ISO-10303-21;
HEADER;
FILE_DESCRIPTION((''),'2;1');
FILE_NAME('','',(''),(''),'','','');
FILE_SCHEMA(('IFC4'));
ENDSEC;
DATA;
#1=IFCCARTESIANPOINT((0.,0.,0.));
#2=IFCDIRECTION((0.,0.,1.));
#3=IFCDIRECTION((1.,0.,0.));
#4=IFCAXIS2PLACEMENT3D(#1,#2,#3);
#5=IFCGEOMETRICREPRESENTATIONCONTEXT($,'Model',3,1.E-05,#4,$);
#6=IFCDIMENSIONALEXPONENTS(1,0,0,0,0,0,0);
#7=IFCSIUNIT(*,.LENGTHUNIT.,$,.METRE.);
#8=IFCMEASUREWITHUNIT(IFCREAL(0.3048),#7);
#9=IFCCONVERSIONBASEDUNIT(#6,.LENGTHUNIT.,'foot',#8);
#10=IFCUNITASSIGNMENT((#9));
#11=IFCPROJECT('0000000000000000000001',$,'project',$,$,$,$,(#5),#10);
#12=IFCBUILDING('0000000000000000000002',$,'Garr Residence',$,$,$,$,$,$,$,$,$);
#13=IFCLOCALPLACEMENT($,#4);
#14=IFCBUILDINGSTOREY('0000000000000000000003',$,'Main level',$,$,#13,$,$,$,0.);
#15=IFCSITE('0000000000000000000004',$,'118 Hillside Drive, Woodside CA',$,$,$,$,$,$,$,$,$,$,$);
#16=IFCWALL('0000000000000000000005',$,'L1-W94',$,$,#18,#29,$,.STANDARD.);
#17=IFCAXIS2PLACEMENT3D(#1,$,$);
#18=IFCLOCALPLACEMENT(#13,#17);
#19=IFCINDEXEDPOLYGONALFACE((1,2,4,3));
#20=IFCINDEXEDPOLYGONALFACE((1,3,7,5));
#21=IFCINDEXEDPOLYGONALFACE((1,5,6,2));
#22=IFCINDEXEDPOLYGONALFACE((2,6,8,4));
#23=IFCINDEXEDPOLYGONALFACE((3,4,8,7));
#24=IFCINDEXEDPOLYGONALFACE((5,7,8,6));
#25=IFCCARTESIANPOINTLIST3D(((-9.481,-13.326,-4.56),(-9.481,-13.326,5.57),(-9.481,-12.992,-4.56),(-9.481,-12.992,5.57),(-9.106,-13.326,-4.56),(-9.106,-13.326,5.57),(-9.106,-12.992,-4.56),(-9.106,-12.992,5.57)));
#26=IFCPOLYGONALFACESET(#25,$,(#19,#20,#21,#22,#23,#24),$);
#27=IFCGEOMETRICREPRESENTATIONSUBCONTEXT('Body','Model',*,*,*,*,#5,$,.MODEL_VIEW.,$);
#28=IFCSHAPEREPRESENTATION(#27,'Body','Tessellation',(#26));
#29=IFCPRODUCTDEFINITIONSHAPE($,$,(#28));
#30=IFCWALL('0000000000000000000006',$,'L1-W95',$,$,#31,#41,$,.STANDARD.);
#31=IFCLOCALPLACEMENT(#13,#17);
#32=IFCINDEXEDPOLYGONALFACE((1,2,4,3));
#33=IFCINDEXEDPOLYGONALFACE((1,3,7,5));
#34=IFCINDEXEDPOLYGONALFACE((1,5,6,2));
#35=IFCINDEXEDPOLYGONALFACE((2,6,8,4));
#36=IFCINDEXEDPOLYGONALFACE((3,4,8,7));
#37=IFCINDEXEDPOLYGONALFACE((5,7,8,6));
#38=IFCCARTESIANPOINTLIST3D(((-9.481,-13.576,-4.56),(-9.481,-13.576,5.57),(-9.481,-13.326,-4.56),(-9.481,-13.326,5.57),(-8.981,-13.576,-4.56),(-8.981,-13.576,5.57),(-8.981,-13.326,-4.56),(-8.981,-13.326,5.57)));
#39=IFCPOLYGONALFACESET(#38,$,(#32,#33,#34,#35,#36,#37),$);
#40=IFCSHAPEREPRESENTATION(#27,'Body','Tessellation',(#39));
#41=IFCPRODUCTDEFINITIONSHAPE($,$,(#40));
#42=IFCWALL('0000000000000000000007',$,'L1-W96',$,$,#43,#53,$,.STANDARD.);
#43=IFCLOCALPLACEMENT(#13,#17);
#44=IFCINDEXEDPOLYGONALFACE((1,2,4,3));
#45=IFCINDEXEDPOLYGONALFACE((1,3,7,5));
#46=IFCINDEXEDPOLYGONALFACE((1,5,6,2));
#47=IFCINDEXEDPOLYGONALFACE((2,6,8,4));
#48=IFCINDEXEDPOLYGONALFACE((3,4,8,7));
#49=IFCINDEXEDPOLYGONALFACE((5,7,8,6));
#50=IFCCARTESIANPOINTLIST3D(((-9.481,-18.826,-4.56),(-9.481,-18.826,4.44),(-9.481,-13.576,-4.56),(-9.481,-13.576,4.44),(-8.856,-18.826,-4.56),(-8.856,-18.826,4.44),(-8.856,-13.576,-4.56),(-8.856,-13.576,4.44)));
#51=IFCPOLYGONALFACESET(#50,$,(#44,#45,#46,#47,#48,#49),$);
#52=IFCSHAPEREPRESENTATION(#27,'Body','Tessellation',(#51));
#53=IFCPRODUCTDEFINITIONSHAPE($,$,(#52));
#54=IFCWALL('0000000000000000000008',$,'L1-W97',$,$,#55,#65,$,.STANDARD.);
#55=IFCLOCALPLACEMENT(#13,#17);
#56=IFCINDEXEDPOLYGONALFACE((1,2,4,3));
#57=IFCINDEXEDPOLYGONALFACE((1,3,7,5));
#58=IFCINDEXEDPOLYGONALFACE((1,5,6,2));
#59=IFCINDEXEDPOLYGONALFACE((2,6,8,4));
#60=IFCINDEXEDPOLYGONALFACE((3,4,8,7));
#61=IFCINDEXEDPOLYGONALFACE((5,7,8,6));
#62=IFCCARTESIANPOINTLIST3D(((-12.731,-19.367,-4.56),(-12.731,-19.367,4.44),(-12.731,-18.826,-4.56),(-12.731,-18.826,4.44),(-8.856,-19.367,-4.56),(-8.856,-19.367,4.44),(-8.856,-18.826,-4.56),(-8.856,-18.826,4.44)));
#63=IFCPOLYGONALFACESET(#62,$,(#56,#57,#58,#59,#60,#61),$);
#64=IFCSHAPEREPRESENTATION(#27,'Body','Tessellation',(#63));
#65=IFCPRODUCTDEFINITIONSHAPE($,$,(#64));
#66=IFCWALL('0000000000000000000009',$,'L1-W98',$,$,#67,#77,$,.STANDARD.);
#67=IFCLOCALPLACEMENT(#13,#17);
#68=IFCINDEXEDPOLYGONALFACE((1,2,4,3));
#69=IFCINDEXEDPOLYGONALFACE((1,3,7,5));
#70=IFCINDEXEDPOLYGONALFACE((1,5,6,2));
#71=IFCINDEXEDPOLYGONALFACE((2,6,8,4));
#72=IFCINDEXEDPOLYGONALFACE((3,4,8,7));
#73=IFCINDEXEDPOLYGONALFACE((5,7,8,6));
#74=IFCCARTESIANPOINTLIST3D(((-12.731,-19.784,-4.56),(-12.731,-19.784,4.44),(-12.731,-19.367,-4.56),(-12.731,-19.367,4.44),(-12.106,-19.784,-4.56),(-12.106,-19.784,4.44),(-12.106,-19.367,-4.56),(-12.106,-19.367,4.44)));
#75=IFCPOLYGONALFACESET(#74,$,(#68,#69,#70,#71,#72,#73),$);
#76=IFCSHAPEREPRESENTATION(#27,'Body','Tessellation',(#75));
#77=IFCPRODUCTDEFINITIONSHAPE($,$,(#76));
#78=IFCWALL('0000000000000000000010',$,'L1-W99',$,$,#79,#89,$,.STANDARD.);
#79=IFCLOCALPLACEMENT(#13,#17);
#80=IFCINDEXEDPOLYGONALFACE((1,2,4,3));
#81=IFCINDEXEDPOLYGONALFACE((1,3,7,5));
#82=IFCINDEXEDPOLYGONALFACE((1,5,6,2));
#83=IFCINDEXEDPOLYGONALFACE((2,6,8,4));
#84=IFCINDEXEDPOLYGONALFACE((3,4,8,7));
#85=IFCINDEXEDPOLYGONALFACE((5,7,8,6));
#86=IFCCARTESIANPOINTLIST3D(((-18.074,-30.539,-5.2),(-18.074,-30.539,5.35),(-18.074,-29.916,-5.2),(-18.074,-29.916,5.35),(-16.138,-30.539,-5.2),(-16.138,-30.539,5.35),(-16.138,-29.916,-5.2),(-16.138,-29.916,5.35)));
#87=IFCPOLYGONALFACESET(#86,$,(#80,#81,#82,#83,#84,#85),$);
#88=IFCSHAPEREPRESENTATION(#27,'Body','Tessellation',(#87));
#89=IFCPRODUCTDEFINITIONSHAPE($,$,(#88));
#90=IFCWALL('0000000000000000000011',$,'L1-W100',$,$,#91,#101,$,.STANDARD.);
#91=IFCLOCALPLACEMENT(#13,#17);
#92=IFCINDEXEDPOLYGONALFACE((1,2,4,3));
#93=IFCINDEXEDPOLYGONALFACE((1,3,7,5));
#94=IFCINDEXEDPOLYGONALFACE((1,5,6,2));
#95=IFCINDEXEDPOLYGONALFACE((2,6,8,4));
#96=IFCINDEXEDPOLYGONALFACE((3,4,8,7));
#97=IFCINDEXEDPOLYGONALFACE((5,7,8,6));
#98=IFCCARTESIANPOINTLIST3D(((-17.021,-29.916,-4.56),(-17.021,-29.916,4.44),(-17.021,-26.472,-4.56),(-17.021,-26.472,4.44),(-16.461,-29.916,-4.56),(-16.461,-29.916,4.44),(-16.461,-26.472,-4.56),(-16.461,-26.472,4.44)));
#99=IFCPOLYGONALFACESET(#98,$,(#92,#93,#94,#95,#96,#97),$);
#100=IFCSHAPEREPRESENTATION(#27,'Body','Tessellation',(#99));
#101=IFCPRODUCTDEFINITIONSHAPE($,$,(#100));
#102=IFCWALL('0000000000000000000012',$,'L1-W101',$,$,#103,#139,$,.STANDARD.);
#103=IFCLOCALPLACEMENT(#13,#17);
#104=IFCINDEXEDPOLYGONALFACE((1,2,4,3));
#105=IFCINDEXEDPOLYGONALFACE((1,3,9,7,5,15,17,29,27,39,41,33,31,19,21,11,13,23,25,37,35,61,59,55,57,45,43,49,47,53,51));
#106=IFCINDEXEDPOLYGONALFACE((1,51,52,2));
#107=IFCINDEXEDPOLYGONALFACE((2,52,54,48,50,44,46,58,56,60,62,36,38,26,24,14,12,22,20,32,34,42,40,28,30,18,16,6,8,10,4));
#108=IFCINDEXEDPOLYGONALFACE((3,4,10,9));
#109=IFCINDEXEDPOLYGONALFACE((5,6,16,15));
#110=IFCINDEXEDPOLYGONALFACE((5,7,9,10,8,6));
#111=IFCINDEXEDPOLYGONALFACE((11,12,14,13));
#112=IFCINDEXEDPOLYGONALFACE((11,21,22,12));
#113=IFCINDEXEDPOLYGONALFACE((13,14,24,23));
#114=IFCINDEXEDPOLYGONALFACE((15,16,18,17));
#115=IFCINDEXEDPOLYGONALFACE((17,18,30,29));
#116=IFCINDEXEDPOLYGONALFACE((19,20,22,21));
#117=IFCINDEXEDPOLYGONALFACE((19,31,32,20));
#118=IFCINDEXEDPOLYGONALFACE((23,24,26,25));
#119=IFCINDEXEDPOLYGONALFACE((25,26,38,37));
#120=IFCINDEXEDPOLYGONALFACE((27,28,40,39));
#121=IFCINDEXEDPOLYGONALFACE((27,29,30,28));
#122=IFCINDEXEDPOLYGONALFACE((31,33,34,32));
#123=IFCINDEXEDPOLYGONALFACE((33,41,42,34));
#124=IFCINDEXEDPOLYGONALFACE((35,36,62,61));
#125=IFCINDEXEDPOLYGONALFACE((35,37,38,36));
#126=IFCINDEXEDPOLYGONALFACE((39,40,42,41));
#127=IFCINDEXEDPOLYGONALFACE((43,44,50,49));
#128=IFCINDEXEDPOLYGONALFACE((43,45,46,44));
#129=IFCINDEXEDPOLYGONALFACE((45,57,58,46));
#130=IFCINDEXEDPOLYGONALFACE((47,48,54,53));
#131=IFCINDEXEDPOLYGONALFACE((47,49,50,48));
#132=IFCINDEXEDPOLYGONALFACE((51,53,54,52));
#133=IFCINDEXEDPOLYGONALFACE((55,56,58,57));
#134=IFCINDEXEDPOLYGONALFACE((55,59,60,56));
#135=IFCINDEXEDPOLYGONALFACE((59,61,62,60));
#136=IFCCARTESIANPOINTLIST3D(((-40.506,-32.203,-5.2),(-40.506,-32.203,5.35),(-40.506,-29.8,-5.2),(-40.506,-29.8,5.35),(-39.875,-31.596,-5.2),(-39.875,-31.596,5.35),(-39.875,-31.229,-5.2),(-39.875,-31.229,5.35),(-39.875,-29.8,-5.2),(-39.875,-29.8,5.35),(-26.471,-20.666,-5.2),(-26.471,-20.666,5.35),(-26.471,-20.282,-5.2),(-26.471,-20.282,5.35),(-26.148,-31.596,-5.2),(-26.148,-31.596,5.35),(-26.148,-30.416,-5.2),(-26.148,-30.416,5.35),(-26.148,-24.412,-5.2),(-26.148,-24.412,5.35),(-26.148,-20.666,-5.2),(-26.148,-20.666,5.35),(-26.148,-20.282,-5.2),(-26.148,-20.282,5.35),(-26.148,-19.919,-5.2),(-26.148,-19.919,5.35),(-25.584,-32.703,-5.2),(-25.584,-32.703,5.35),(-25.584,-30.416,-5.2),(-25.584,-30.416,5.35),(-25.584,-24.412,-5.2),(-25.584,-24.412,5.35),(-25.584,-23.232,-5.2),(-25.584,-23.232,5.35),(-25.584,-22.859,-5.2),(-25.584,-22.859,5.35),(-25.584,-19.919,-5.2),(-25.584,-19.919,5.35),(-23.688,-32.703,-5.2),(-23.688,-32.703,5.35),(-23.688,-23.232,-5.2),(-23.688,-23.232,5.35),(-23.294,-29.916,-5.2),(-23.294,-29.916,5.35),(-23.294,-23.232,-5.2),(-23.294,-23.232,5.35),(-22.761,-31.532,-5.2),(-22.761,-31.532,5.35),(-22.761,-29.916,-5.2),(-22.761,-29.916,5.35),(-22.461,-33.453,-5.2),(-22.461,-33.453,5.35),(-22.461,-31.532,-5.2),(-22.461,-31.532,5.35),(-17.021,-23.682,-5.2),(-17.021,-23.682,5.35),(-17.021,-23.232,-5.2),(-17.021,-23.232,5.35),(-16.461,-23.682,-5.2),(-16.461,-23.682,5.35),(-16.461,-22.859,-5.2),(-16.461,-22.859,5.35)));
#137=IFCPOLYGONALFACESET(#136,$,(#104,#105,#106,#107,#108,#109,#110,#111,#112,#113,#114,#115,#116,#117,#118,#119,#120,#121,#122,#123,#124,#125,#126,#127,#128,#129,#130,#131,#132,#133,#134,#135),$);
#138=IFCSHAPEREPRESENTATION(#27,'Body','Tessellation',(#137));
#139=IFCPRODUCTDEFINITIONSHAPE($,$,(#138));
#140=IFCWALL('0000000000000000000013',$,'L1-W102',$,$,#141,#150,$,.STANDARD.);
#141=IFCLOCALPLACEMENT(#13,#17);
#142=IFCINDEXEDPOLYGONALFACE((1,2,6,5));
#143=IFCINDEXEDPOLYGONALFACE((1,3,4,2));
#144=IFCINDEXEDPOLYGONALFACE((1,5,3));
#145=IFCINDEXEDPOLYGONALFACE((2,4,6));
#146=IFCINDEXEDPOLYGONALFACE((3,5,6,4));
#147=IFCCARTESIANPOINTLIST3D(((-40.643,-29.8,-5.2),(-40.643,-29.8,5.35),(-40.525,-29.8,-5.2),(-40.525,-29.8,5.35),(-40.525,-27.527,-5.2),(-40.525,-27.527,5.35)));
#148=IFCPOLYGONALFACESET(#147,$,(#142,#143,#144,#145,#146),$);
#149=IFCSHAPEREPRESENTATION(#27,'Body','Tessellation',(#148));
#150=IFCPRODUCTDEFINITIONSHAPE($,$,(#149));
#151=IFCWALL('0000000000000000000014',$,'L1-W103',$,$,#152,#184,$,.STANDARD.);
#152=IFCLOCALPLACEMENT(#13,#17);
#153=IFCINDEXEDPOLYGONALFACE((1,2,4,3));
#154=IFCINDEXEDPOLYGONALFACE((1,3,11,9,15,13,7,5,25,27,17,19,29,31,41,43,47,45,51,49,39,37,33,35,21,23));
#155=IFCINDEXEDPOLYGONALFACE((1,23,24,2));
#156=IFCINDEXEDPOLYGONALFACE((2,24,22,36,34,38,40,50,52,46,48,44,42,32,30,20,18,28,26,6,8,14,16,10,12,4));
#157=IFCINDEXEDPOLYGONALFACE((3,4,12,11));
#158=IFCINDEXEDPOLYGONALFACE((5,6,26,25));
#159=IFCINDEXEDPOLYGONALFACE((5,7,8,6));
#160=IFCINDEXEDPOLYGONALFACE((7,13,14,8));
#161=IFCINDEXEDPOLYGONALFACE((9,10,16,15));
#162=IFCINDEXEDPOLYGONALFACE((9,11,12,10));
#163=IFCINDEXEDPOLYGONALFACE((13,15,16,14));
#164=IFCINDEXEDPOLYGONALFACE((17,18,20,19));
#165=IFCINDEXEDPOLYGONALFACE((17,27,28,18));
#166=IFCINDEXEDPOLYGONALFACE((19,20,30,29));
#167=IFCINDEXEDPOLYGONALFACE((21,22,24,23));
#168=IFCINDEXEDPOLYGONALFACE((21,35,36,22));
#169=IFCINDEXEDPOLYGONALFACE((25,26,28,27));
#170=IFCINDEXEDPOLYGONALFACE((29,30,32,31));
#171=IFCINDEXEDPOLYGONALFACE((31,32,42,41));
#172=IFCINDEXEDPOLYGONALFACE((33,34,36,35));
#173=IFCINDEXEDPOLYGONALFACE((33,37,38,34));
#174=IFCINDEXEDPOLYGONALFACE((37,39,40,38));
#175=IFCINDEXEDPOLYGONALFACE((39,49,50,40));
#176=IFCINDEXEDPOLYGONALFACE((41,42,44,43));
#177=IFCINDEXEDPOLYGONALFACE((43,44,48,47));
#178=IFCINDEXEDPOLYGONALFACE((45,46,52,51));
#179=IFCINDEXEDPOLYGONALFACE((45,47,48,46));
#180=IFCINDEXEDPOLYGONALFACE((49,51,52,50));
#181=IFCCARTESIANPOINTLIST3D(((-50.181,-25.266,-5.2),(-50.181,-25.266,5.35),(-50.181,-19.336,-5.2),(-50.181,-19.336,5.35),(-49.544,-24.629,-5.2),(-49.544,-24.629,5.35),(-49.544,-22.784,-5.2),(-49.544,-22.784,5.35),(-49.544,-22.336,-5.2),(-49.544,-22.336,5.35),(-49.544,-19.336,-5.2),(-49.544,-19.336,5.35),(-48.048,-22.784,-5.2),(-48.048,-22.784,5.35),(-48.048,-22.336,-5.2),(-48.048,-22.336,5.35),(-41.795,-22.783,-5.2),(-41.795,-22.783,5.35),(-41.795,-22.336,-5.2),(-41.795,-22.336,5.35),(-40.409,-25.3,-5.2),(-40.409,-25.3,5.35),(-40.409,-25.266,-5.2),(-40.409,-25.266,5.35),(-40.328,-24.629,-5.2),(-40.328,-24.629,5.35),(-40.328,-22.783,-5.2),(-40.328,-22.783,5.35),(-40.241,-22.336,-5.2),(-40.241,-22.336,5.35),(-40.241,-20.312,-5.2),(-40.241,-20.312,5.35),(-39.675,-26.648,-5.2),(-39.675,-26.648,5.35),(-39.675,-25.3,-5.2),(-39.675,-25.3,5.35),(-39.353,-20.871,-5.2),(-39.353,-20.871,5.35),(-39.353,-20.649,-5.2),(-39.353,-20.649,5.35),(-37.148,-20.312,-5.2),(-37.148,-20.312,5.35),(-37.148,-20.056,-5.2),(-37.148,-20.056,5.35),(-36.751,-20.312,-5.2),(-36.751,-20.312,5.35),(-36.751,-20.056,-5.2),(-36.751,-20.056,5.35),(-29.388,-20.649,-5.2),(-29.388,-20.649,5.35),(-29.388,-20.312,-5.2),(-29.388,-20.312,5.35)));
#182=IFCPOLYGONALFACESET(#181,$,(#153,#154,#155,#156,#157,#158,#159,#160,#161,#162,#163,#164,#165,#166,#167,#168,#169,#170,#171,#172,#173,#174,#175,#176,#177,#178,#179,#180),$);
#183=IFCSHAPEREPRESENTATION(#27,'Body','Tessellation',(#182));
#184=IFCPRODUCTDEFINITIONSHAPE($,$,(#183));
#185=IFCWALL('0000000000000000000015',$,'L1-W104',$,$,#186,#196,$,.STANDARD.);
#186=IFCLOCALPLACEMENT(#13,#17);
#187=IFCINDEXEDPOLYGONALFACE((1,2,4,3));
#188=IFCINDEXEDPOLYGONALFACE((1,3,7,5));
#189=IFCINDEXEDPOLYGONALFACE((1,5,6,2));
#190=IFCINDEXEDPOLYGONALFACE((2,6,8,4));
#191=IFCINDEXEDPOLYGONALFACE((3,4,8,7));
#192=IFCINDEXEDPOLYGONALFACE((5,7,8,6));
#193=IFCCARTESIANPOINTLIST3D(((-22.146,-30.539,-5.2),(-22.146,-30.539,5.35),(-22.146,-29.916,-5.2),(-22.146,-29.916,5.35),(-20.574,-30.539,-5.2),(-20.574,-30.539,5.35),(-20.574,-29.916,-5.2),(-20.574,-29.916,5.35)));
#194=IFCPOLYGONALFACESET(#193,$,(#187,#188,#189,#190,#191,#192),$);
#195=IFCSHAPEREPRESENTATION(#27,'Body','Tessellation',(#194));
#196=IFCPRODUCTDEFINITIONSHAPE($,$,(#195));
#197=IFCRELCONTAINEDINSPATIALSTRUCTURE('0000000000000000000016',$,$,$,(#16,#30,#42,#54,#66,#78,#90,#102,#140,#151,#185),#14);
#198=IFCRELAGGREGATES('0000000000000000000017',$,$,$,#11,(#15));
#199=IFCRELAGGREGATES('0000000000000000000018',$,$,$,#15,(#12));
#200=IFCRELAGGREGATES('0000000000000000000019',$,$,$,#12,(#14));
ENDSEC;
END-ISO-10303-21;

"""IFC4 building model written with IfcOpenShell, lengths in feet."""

from ifc_helpers import new_model, entity, si_unit, converted_unit, frame, origin, origin_with_axes, place, context, subcontext, project, spatial, polyline, outline, extrude, element, save


model = new_model("IFC4")

# Units and contexts
model_context = context("Model", 3, precision=1e-05, world=origin_with_axes())
body_context = subcontext(model_context, "Body", "Model", "MODEL_VIEW")
ifc_project = project(units=[converted_unit("LENGTHUNIT", "foot", entity("IfcReal", 0.3048), si_unit("LENGTHUNIT", "METRE"), dimensions=[1, 0, 0, 0, 0, 0, 0])], contexts=[model_context])

# Site, building, storey
site = spatial("IfcSite", under=ifc_project, Name="118 Hillside Drive, Woodside CA")
building = spatial("IfcBuilding", under=site, Name="Garr Residence")
storey_placement = place(None, origin_with_axes())
storey = spatial("IfcBuildingStorey", under=building, at=storey_placement, Name="Main level", Elevation=0.0)

# Walls
wall_1_placement = place(storey_placement, frame((0.0, 0.0, -4.56), z_axis=(0.0, 0.0, 1.0), x_axis=(1.0, 0.0, 0.0)))
element("IfcWall", 1, at=wall_1_placement, inside=storey, Name="L1-W94", PredefinedType="STANDARD", context=body_context, shape_type="SweptSolid", body=[
    extrude(outline(polyline([(-9.106, -13.326), (-9.106, -12.992), (-9.481, -12.992), (-9.481, -13.326), (-9.106, -13.326)])), origin(), (0.0, 0.0, 1.0), 10.13),
])
wall_2_placement = place(storey_placement, frame((0.0, 0.0, -4.56), z_axis=(0.0, 0.0, 1.0), x_axis=(1.0, 0.0, 0.0)))
element("IfcWall", 2, at=wall_2_placement, inside=storey, Name="L1-W95", PredefinedType="STANDARD", context=body_context, shape_type="SweptSolid", body=[
    extrude(outline(polyline([(-8.981, -13.576), (-8.981, -13.326), (-9.481, -13.326), (-9.481, -13.576), (-8.981, -13.576)])), origin(), (0.0, 0.0, 1.0), 10.13),
])
wall_3_placement = place(storey_placement, frame((0.0, 0.0, -4.56), z_axis=(0.0, 0.0, 1.0), x_axis=(1.0, 0.0, 0.0)))
element("IfcWall", 3, at=wall_3_placement, inside=storey, Name="L1-W96", PredefinedType="STANDARD", context=body_context, shape_type="SweptSolid", body=[
    extrude(outline(polyline([(-8.856, -18.826), (-8.856, -13.576), (-9.481, -13.576), (-9.481, -18.826), (-8.856, -18.826)])), origin(), (0.0, 0.0, 1.0), 9.0),
])
wall_4_placement = place(storey_placement, frame((0.0, 0.0, -4.56), z_axis=(0.0, 0.0, 1.0), x_axis=(1.0, 0.0, 0.0)))
element("IfcWall", 4, at=wall_4_placement, inside=storey, Name="L1-W97", PredefinedType="STANDARD", context=body_context, shape_type="SweptSolid", body=[
    extrude(outline(polyline([(-8.856, -19.367), (-8.856, -18.826), (-12.731, -18.826), (-12.731, -19.367), (-8.856, -19.367)])), origin(), (0.0, 0.0, 1.0), 9.0),
])
wall_5_placement = place(storey_placement, frame((0.0, 0.0, -4.56), z_axis=(0.0, 0.0, 1.0), x_axis=(1.0, 0.0, 0.0)))
element("IfcWall", 5, at=wall_5_placement, inside=storey, Name="L1-W98", PredefinedType="STANDARD", context=body_context, shape_type="SweptSolid", body=[
    extrude(outline(polyline([(-12.106, -19.784), (-12.106, -19.367), (-12.731, -19.367), (-12.731, -19.784), (-12.106, -19.784)])), origin(), (0.0, 0.0, 1.0), 9.0),
])
wall_6_placement = place(storey_placement, frame((0.0, 0.0, -5.2), z_axis=(0.0, 0.0, 1.0), x_axis=(1.0, 0.0, 0.0)))
element("IfcWall", 6, at=wall_6_placement, inside=storey, Name="L1-W99", PredefinedType="STANDARD", context=body_context, shape_type="SweptSolid", body=[
    extrude(outline(polyline([(-16.138, -30.539), (-16.138, -29.916), (-18.074, -29.916), (-18.074, -30.539), (-16.138, -30.539)])), origin(), (0.0, 0.0, 1.0), 10.55),
])
wall_7_placement = place(storey_placement, frame((0.0, 0.0, -4.56), z_axis=(0.0, 0.0, 1.0), x_axis=(1.0, 0.0, 0.0)))
element("IfcWall", 7, at=wall_7_placement, inside=storey, Name="L1-W100", PredefinedType="STANDARD", context=body_context, shape_type="SweptSolid", body=[
    extrude(outline(polyline([(-16.461, -29.916), (-16.461, -26.472), (-17.021, -26.472), (-17.021, -29.916), (-16.461, -29.916)])), origin(), (0.0, 0.0, 1.0), 9.0),
])
wall_8_placement = place(storey_placement, frame((0.0, 0.0, -5.2), z_axis=(0.0, 0.0, 1.0), x_axis=(1.0, 0.0, 0.0)))
element("IfcWall", 8, at=wall_8_placement, inside=storey, Name="L1-W101", PredefinedType="STANDARD", context=body_context, shape_type="SweptSolid", body=[
    extrude(outline(polyline([(-25.584, -30.416), (-25.584, -32.703), (-23.688, -32.703), (-23.688, -23.232), (-25.584, -23.232), (-25.584, -24.412), (-26.148, -24.412), (-26.148, -20.666), (-26.471, -20.666), (-26.471, -20.282), (-26.148, -20.282), (-26.148, -19.919), (-25.584, -19.919), (-25.584, -22.859), (-16.461, -22.859), (-16.461, -23.682), (-17.021, -23.682), (-17.021, -23.232), (-23.294, -23.232), (-23.294, -29.916), (-22.761, -29.916), (-22.761, -31.532), (-22.461, -31.532), (-22.461, -33.453), (-40.506, -32.203), (-40.506, -29.8), (-39.875, -29.8), (-39.875, -31.229), (-39.875, -31.596), (-26.148, -31.596), (-26.148, -30.416), (-25.584, -30.416)])), origin(), (0.0, 0.0, 1.0), 10.55),
])
wall_9_placement = place(storey_placement, frame((0.0, 0.0, -5.2), z_axis=(0.0, 0.0, 1.0), x_axis=(1.0, 0.0, 0.0)))
element("IfcWall", 9, at=wall_9_placement, inside=storey, Name="L1-W102", PredefinedType="STANDARD", context=body_context, shape_type="SweptSolid", body=[
    extrude(outline(polyline([(-40.525, -27.527), (-40.525, -29.8), (-40.643, -29.8), (-40.525, -27.527)])), origin(), (0.0, 0.0, 1.0), 10.55),
])
wall_10_placement = place(storey_placement, frame((0.0, 0.0, -5.2), z_axis=(0.0, 0.0, 1.0), x_axis=(1.0, 0.0, 0.0)))
element("IfcWall", 10, at=wall_10_placement, inside=storey, Name="L1-W103", PredefinedType="STANDARD", context=body_context, shape_type="SweptSolid", body=[
    extrude(outline(polyline([(-49.544, -22.336), (-48.048, -22.336), (-48.048, -22.784), (-49.544, -22.784), (-49.544, -24.629), (-40.328, -24.629), (-40.328, -22.783), (-41.795, -22.783), (-41.795, -22.336), (-40.241, -22.336), (-40.241, -20.312), (-37.148, -20.312), (-37.148, -20.056), (-36.751, -20.056), (-36.751, -20.312), (-29.388, -20.312), (-29.388, -20.649), (-39.353, -20.649), (-39.353, -20.871), (-39.675, -26.648), (-39.675, -25.3), (-40.409, -25.3), (-40.409, -25.266), (-50.181, -25.266), (-50.181, -19.336), (-49.544, -19.336), (-49.544, -22.336)])), origin(), (0.0, 0.0, 1.0), 10.55),
])
wall_11_placement = place(storey_placement, frame((0.0, 0.0, -5.2), z_axis=(0.0, 0.0, 1.0), x_axis=(1.0, 0.0, 0.0)))
element("IfcWall", 11, at=wall_11_placement, inside=storey, Name="L1-W104", PredefinedType="STANDARD", context=body_context, shape_type="SweptSolid", body=[
    extrude(outline(polyline([(-20.574, -30.539), (-20.574, -29.916), (-22.146, -29.916), (-22.146, -30.539), (-20.574, -30.539)])), origin(), (0.0, 0.0, 1.0), 10.55),
])

save(model, "model.ifc")
